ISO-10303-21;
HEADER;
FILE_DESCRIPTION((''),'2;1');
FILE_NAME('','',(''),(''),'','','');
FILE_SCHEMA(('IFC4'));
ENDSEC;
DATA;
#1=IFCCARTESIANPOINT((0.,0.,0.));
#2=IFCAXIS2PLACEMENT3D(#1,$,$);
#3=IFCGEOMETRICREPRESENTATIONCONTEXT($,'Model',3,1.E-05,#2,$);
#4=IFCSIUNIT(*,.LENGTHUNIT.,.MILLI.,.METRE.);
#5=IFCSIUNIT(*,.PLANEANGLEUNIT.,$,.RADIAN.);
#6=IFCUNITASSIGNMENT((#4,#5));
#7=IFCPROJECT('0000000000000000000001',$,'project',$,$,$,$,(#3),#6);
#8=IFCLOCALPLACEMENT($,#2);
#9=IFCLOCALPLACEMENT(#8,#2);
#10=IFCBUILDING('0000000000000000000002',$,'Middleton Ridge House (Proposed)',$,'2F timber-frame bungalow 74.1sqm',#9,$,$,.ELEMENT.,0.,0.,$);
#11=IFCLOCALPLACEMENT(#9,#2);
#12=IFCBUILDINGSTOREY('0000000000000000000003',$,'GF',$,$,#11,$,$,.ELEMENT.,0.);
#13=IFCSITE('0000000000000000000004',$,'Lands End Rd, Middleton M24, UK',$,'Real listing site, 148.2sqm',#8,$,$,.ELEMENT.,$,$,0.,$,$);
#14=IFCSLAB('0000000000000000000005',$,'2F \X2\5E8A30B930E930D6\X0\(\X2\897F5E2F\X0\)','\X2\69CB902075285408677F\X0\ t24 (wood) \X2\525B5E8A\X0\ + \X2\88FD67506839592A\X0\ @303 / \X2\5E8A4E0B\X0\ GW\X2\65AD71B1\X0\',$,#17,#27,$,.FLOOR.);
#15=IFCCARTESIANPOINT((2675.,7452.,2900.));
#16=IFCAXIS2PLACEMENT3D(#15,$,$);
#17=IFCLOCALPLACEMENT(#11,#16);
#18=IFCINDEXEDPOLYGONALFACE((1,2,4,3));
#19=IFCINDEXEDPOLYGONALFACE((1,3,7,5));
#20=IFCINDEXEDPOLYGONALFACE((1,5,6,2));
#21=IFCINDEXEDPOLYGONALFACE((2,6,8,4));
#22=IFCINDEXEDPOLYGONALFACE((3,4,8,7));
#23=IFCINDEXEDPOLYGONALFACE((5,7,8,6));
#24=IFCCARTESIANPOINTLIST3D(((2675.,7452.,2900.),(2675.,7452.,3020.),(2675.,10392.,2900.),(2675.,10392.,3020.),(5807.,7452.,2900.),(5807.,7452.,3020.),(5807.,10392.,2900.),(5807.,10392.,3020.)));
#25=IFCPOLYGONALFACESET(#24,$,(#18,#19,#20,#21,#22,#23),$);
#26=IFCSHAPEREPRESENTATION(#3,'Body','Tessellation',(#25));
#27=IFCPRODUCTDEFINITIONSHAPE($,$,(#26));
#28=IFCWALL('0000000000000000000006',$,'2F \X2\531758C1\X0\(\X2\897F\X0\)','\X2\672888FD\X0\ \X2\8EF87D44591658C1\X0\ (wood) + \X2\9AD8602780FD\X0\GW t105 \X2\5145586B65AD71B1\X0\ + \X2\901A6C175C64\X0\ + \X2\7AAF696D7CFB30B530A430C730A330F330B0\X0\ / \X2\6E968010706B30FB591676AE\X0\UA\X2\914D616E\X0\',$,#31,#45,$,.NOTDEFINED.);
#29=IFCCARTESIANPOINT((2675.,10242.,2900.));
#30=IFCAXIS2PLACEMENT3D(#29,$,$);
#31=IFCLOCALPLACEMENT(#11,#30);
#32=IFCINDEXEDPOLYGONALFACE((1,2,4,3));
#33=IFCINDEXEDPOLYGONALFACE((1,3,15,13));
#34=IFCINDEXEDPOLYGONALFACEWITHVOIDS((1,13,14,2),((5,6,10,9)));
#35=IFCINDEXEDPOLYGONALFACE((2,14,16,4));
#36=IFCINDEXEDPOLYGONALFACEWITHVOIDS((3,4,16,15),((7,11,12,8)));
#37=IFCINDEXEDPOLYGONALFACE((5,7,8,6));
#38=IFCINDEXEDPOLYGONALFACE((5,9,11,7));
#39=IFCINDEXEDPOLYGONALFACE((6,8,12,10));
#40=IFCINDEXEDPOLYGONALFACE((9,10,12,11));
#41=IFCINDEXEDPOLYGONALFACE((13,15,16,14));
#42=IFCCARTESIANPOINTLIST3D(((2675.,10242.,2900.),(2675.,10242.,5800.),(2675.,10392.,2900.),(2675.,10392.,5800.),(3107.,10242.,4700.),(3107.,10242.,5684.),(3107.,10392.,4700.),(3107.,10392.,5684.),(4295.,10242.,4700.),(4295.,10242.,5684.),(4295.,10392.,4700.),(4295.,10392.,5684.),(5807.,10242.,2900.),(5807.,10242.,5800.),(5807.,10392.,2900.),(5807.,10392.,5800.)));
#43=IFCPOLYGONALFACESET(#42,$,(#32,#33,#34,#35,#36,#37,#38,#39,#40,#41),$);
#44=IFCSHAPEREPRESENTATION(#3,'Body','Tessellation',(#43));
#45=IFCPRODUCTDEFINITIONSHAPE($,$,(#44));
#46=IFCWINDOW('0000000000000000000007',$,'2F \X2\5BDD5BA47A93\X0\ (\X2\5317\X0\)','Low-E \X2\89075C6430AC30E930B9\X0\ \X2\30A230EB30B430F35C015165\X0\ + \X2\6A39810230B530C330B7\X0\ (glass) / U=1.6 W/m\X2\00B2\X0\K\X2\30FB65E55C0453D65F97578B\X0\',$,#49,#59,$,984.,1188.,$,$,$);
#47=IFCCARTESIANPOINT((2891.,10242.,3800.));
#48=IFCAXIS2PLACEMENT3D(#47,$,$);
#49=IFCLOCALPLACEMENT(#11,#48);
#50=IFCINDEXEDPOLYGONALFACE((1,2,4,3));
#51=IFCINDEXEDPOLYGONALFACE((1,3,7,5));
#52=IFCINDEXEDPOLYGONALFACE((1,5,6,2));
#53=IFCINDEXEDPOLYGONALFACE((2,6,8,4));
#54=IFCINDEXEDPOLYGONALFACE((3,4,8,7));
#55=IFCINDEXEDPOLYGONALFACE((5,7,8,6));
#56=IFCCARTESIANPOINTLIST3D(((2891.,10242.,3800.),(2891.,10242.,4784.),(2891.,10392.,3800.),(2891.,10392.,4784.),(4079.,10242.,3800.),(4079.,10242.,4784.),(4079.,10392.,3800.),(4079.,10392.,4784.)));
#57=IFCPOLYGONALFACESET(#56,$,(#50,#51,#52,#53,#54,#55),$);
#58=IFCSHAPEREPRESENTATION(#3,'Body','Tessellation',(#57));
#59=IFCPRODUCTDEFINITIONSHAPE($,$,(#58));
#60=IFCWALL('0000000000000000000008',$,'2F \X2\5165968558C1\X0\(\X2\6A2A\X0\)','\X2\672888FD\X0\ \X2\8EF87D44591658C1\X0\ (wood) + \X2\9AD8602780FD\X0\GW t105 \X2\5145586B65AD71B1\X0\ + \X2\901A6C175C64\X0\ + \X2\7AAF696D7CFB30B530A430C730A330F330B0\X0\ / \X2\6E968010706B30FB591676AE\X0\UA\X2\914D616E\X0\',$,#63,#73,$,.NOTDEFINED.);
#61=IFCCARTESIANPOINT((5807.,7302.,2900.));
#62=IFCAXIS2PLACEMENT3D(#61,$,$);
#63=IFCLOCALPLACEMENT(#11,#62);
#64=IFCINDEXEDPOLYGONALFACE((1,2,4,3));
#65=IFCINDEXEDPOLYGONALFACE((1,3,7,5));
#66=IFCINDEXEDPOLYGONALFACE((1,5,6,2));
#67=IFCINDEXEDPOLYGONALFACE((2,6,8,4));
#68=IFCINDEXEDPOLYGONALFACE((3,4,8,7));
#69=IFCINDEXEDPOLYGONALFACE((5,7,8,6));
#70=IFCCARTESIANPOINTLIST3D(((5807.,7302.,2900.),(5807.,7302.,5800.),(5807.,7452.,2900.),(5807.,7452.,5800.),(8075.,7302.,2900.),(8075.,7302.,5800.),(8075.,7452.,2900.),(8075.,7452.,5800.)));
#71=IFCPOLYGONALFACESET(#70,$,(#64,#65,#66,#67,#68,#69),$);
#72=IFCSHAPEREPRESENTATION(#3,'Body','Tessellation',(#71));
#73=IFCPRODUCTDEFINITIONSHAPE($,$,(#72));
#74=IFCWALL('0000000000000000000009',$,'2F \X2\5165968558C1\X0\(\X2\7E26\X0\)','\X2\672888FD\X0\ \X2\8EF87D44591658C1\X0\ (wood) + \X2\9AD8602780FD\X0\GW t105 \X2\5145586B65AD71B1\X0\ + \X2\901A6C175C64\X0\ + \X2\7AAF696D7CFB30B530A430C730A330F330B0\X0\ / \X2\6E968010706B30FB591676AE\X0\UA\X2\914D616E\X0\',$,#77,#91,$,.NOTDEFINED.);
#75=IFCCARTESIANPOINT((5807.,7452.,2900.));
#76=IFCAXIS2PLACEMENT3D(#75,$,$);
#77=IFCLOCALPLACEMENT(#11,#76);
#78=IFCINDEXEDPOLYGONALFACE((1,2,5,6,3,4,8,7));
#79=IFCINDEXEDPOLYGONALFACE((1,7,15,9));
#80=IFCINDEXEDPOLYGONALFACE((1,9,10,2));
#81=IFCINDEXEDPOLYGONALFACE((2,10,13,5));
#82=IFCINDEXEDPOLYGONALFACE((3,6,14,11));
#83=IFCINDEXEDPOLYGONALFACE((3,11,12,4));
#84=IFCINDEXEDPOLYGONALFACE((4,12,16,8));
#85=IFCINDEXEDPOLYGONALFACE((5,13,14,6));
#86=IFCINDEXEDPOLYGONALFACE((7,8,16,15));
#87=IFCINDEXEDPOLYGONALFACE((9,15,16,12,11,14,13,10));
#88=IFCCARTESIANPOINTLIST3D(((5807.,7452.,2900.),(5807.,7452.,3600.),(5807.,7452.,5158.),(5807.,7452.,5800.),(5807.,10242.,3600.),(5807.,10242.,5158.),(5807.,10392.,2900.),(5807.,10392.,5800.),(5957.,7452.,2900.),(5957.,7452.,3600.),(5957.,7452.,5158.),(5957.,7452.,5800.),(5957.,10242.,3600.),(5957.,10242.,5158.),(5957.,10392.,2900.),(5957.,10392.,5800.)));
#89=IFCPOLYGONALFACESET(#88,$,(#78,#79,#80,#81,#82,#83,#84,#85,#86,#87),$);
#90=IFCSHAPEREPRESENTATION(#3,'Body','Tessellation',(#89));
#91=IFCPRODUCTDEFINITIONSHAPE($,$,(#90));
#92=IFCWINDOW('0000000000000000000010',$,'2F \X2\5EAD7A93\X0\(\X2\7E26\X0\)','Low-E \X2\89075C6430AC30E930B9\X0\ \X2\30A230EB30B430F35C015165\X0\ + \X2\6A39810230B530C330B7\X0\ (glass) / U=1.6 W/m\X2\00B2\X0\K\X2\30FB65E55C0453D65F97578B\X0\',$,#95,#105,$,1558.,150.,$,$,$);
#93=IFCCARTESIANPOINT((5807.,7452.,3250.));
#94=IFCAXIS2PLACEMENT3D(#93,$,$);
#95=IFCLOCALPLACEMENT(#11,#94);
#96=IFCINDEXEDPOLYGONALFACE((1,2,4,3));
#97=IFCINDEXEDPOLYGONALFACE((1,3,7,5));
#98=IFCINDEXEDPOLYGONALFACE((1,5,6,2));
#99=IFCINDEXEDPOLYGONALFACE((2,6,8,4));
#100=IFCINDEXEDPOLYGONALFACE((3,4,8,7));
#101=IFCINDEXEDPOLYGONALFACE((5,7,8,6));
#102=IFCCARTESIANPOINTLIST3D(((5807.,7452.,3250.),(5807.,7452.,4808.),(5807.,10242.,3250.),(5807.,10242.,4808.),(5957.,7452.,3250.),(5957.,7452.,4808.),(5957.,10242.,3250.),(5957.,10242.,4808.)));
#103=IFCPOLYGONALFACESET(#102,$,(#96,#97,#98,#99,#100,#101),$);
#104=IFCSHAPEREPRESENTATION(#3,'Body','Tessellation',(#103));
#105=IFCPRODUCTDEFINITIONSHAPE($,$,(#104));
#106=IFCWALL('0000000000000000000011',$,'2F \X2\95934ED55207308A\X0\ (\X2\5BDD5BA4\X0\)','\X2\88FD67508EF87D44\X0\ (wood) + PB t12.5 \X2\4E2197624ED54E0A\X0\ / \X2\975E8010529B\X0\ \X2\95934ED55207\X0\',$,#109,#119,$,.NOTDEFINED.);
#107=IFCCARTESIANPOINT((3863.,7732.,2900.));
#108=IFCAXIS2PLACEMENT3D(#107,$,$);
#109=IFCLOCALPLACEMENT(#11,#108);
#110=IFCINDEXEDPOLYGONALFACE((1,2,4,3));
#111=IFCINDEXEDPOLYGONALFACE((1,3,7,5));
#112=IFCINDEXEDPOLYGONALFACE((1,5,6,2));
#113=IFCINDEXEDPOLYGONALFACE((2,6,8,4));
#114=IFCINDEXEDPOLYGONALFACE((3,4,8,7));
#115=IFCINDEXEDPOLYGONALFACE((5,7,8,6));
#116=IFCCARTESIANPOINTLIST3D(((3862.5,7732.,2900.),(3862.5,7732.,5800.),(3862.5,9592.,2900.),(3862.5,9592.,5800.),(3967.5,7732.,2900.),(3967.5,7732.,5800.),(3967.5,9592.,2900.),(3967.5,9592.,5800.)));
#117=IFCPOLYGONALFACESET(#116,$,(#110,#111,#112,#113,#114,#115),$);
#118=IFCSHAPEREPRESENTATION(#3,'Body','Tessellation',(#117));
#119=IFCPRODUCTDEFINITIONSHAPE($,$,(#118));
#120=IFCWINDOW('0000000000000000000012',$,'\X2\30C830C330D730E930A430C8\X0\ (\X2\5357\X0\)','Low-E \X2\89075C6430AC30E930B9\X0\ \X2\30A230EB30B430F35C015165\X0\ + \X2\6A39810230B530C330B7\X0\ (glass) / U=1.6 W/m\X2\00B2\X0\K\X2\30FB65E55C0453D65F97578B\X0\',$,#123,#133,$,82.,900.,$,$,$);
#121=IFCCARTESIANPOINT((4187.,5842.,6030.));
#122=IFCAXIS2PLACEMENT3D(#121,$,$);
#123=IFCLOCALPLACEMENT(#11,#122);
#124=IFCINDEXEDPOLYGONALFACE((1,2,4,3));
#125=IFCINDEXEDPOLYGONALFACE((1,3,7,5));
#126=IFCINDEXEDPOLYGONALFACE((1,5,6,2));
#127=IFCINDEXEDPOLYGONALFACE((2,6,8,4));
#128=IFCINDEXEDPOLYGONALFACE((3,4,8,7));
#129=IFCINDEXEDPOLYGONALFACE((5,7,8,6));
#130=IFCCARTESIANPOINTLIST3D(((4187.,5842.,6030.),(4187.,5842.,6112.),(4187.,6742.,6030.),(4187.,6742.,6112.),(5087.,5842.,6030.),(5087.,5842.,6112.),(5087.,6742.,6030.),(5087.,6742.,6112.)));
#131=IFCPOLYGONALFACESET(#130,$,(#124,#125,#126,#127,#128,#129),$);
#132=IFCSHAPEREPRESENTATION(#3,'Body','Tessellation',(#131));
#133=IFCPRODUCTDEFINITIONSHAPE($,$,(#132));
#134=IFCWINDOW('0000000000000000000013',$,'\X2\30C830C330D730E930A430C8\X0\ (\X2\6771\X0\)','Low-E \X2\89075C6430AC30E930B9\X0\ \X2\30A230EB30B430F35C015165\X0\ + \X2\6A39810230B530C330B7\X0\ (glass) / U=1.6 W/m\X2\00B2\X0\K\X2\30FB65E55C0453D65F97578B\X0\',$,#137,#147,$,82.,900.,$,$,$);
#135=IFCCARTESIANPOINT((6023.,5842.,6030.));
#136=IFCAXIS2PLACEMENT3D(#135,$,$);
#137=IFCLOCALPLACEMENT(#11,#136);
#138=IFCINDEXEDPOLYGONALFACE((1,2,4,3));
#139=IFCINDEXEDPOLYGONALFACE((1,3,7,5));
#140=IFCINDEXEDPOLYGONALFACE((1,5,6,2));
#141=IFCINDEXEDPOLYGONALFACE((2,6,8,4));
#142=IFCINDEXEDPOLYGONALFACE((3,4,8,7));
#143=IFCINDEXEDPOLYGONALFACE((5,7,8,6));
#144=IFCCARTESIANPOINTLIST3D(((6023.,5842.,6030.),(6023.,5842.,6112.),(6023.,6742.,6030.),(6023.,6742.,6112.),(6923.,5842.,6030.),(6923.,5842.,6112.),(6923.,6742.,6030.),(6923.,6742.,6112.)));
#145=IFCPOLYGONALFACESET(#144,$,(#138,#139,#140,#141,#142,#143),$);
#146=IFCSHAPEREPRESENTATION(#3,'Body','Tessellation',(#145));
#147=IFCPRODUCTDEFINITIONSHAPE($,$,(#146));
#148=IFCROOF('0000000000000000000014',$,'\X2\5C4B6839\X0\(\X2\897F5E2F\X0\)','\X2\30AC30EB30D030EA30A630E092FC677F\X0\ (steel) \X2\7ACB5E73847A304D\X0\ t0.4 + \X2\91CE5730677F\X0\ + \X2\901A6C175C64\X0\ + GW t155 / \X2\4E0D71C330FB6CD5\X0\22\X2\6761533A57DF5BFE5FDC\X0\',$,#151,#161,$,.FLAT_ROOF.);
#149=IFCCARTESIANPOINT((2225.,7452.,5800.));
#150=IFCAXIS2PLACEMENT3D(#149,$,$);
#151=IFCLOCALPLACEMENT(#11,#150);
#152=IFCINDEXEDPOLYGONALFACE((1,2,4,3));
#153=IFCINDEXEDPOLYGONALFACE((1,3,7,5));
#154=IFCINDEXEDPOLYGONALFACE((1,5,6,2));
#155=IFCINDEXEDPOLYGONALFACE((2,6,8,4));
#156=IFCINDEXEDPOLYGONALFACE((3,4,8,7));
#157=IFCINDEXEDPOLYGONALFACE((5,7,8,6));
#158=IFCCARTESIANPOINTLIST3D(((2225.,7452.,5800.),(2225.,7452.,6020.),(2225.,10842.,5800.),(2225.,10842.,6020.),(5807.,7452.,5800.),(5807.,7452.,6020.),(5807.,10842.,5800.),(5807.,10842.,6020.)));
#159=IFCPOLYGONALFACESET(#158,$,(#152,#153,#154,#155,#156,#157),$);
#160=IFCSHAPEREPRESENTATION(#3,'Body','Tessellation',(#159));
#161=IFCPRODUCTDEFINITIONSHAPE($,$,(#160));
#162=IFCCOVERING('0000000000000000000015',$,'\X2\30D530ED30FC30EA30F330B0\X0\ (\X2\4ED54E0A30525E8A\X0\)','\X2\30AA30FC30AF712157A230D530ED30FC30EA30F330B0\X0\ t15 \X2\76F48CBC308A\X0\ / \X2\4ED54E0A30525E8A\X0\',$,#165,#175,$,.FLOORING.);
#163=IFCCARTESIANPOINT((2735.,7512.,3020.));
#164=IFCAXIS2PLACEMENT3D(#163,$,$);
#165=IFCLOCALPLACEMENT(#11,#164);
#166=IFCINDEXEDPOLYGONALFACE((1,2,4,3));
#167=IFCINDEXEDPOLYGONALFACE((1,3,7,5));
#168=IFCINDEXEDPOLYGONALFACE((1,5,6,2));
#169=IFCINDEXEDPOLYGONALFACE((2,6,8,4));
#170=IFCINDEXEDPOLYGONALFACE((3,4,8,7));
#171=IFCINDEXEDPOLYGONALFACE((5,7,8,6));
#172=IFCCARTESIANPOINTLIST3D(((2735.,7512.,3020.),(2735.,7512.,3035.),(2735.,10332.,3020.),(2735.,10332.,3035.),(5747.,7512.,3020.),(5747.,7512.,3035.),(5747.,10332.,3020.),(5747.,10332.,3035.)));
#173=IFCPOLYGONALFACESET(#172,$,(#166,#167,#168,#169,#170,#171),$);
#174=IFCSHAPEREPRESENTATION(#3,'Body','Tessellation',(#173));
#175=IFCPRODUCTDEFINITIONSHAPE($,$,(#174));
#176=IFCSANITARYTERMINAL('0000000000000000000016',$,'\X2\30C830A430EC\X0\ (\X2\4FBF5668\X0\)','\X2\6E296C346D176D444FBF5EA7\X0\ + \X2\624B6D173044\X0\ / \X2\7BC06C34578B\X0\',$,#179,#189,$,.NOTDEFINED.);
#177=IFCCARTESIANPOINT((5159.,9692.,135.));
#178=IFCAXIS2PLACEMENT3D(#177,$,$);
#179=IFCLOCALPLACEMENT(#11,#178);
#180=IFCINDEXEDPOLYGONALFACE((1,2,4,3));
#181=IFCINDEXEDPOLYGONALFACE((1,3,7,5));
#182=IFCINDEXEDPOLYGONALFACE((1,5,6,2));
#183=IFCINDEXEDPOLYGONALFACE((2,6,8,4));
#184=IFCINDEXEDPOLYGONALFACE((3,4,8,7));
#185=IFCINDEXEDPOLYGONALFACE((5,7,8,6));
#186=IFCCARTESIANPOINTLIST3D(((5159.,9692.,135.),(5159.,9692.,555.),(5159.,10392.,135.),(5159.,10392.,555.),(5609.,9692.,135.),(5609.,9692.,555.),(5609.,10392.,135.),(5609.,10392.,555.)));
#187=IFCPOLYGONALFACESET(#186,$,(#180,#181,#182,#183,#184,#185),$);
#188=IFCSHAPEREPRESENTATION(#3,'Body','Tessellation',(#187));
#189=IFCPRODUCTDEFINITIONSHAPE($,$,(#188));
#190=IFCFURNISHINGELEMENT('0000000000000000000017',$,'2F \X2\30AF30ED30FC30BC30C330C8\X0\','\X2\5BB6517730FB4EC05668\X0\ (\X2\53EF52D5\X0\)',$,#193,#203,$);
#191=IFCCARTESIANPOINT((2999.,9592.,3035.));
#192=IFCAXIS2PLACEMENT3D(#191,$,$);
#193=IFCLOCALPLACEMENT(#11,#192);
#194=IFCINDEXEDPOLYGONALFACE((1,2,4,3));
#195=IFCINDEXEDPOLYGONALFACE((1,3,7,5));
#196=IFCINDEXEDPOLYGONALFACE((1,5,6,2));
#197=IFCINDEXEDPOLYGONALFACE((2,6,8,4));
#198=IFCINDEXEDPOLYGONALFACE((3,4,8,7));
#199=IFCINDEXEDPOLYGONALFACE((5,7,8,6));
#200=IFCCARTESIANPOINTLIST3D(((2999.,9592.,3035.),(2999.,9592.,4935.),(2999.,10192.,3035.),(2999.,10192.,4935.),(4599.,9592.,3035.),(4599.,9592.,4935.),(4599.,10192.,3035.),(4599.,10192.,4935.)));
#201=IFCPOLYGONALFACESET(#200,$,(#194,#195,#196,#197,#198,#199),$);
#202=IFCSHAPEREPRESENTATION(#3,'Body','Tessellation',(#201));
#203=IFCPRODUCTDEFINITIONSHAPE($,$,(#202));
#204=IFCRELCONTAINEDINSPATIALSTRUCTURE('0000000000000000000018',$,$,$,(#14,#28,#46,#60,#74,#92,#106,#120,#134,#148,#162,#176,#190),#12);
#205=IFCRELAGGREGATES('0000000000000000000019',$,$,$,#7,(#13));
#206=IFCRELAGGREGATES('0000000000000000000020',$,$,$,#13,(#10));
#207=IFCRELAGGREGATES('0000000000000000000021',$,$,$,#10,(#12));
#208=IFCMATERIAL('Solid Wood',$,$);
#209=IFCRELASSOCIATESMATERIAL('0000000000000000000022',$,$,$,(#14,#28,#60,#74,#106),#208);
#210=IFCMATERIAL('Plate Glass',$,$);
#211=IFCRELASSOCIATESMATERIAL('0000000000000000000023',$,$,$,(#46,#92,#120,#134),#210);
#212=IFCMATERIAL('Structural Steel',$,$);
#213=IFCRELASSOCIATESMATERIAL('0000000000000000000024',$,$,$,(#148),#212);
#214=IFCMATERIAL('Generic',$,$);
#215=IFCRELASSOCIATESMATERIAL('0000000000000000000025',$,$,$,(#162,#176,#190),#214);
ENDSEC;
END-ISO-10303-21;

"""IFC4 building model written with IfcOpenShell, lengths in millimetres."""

from ifc_helpers import new_model, si_unit, frame, frame_2d, origin, place, context, project, spatial, rectangle, extrude, material, element, fill, save


model = new_model("IFC4")

# Units and contexts
model_context = context("Model", 3, precision=1e-05, world=origin())
ifc_project = project(units=[si_unit("LENGTHUNIT", "METRE", prefix="MILLI"), si_unit("PLANEANGLEUNIT", "RADIAN")], contexts=[model_context])

# Site, building, storey
site_placement = place(None, origin())
site = spatial("IfcSite", under=ifc_project, at=site_placement, Name="Lands End Rd, Middleton M24, UK", ObjectType="Real listing site, 148.2sqm", CompositionType="ELEMENT", RefElevation=0.0)
building_placement = place(site_placement, origin())
building = spatial("IfcBuilding", under=site, at=building_placement, Name="Middleton Ridge House (Proposed)", ObjectType="2F timber-frame bungalow 74.1sqm", CompositionType="ELEMENT", ElevationOfRefHeight=0.0, ElevationOfTerrain=0.0)
storey_placement = place(building_placement, origin())
storey = spatial("IfcBuildingStorey", under=building, at=storey_placement, Name="GF", CompositionType="ELEMENT", Elevation=0.0)

# Slab
ifc_material_1 = material(Name="Solid Wood")
slab_placement = place(storey_placement, frame((2675.0, 7452.0, 2900.0)))
element("IfcSlab", 1, at=slab_placement, inside=storey, material=ifc_material_1, Name="2F 床スラブ(西帯)", Description="構造用合板 t24 (wood) 剛床 + 製材根太 @303 / 床下 GW断熱", PredefinedType="FLOOR", context=model_context, shape_type="SweptSolid", body=[
    extrude(rectangle(XDim=3132.0, YDim=2940.0, at=frame_2d((1566.0, 1470.0))), frame((2675.0, 7452.0, 2900.0)), (0.0, 0.0, 1.0), 120.0),
])

# Wall, opening, window
wall_1_placement = place(storey_placement, frame((2675.0, 10242.0, 2900.0)))
wall_1 = element("IfcWall", 2, at=wall_1_placement, inside=storey, material=ifc_material_1, Name="2F 北壁(西)", Description="木製 軸組外壁 (wood) + 高性能GW t105 充填断熱 + 通気層 + 窯業系サイディング / 準耐火・外皮UA配慮", PredefinedType="NOTDEFINED", context=model_context, shape_type="SweptSolid", body=[
    extrude(rectangle(XDim=3132.0, YDim=150.0, at=frame_2d((1566.0, 75.0))), frame((2675.0, 10242.0, 2900.0)), (0.0, 0.0, 1.0), 2900.0),
])
opening_1_placement = place(storey_placement, frame((2891.0, 10242.0, 3800.0)))
opening_1 = element("IfcOpeningElement", 3, at=opening_1_placement, cuts=wall_1, PredefinedType="NOTDEFINED", context=model_context, shape_type="SweptSolid", body=[
    extrude(rectangle(XDim=1188.0, YDim=150.0, at=frame_2d((594.0, 75.0))), frame((2891.0, 10242.0, 3800.0)), (0.0, 0.0, 1.0), 984.0),
])
ifc_material_2 = material(Name="Plate Glass")
window_1_placement = place(storey_placement, frame((2891.0, 10242.0, 3800.0)))
window_1 = element("IfcWindow", 4, at=window_1_placement, inside=storey, material=ifc_material_2, Name="2F 寝室窓 (北)", Description="Low-E 複層ガラス アルゴン封入 + 樹脂サッシ (glass) / U=1.6 W/m²K・日射取得型", OverallHeight=984.0, OverallWidth=1188.0, context=model_context, shape_type="SweptSolid", body=[
    extrude(rectangle(XDim=1188.0, YDim=150.0, at=frame_2d((594.0, 75.0))), frame((2891.0, 10242.0, 3800.0)), (0.0, 0.0, 1.0), 984.0),
])
fill(opening_1, window_1)

# Wall
wall_2_placement = place(storey_placement, frame((5807.0, 7302.0, 2900.0)))
element("IfcWall", 5, at=wall_2_placement, inside=storey, material=ifc_material_1, Name="2F 入隅壁(横)", Description="木製 軸組外壁 (wood) + 高性能GW t105 充填断熱 + 通気層 + 窯業系サイディング / 準耐火・外皮UA配慮", PredefinedType="NOTDEFINED", context=model_context, shape_type="SweptSolid", body=[
    extrude(rectangle(XDim=2268.0, YDim=150.0, at=frame_2d((1134.0, 75.0))), frame((5807.0, 7302.0, 2900.0)), (0.0, 0.0, 1.0), 2900.0),
])

# Wall, opening, window
wall_3_placement = place(storey_placement, frame((5807.0, 7452.0, 2900.0)))
wall_3 = element("IfcWall", 6, at=wall_3_placement, inside=storey, material=ifc_material_1, Name="2F 入隅壁(縦)", Description="木製 軸組外壁 (wood) + 高性能GW t105 充填断熱 + 通気層 + 窯業系サイディング / 準耐火・外皮UA配慮", PredefinedType="NOTDEFINED", context=model_context, shape_type="SweptSolid", body=[
    extrude(rectangle(XDim=150.0, YDim=2940.0, at=frame_2d((75.0, 1470.0))), frame((5807.0, 7452.0, 2900.0)), (0.0, 0.0, 1.0), 2900.0),
])
opening_2_placement = place(storey_placement, frame((5807.0, 7452.0, 3250.0)))
opening_2 = element("IfcOpeningElement", 7, at=opening_2_placement, cuts=wall_3, PredefinedType="NOTDEFINED", context=model_context, shape_type="SweptSolid", body=[
    extrude(rectangle(XDim=150.0, YDim=2790.0, at=frame_2d((75.0, 1395.0))), frame((5807.0, 7452.0, 3250.0)), (0.0, 0.0, 1.0), 1558.0),
])
window_2_placement = place(storey_placement, frame((5807.0, 7452.0, 3250.0)))
window_2 = element("IfcWindow", 8, at=window_2_placement, inside=storey, material=ifc_material_2, Name="2F 庭窓(縦)", Description="Low-E 複層ガラス アルゴン封入 + 樹脂サッシ (glass) / U=1.6 W/m²K・日射取得型", OverallHeight=1558.0, OverallWidth=150.0, context=model_context, shape_type="SweptSolid", body=[
    extrude(rectangle(XDim=150.0, YDim=2790.0, at=frame_2d((75.0, 1395.0))), frame((5807.0, 7452.0, 3250.0)), (0.0, 0.0, 1.0), 1558.0),
])
fill(opening_2, window_2)

# Wall
wall_4_placement = place(storey_placement, frame((3863.0, 7732.0, 2900.0)))
element("IfcWall", 9, at=wall_4_placement, inside=storey, material=ifc_material_1, Name="2F 間仕切り (寝室)", Description="製材軸組 (wood) + PB t12.5 両面仕上 / 非耐力 間仕切", PredefinedType="NOTDEFINED", context=model_context, shape_type="SweptSolid", body=[
    extrude(rectangle(XDim=105.0, YDim=1860.0, at=frame_2d((52.0, 930.0))), frame((3863.0, 7732.0, 2900.0)), (0.0, 0.0, 1.0), 2900.0),
])

# Windows
window_3_placement = place(storey_placement, frame((4187.0, 5842.0, 6030.0)))
element("IfcWindow", 10, at=window_3_placement, inside=storey, material=ifc_material_2, Name="トップライト (南)", Description="Low-E 複層ガラス アルゴン封入 + 樹脂サッシ (glass) / U=1.6 W/m²K・日射取得型", OverallHeight=82.0, OverallWidth=900.0, context=model_context, shape_type="SweptSolid", body=[
    extrude(rectangle(XDim=900.0, YDim=900.0, at=frame_2d((450.0, 450.0))), frame((4187.0, 5842.0, 6030.0)), (0.0, 0.0, 1.0), 82.0),
])
window_4_placement = place(storey_placement, frame((6023.0, 5842.0, 6030.0)))
element("IfcWindow", 11, at=window_4_placement, inside=storey, material=ifc_material_2, Name="トップライト (東)", Description="Low-E 複層ガラス アルゴン封入 + 樹脂サッシ (glass) / U=1.6 W/m²K・日射取得型", OverallHeight=82.0, OverallWidth=900.0, context=model_context, shape_type="SweptSolid", body=[
    extrude(rectangle(XDim=900.0, YDim=900.0, at=frame_2d((450.0, 450.0))), frame((6023.0, 5842.0, 6030.0)), (0.0, 0.0, 1.0), 82.0),
])

# Roof
ifc_material_3 = material(Name="Structural Steel")
for number, where, name in (
    (12, (2225.0, 7452.0, 5800.0), "屋根(西帯)"),
):
    element("IfcRoof", number, at=place(storey_placement, frame(where)), inside=storey, material=ifc_material_3, Name=name, Description="ガルバリウム鋼板 (steel) 立平葺き t0.4 + 野地板 + 通気層 + GW t155 / 不燃・法22条区域対応", PredefinedType="FLAT_ROOF", context=model_context, shape_type="SweptSolid", body=[
        extrude(rectangle(XDim=3582.0, YDim=3390.0, at=frame_2d((1791.0, 1695.0))), frame((2225.0, 7452.0, 5800.0)), (0.0, 0.0, 1.0), 220.0),
    ])

# Covering
ifc_material_4 = material(Name="Generic")
covering_placement = place(storey_placement, frame((2735.0, 7512.0, 3020.0)))
element("IfcCovering", 13, at=covering_placement, inside=storey, material=ifc_material_4, Name="フローリング (仕上げ床)", Description="オーク無垢フローリング t15 直貼り / 仕上げ床", PredefinedType="FLOORING", context=model_context, shape_type="SweptSolid", body=[
    extrude(rectangle(XDim=3012.0, YDim=2820.0, at=frame_2d((1506.0, 1410.0))), frame((2735.0, 7512.0, 3020.0)), (0.0, 0.0, 1.0), 15.0),
])

# Sanitary terminal
sanitary_terminal_placement = place(storey_placement, frame((5159.0, 9692.0, 135.0)))
element("IfcSanitaryTerminal", 14, at=sanitary_terminal_placement, inside=storey, material=ifc_material_4, Name="トイレ (便器)", Description="温水洗浄便座 + 手洗い / 節水型", PredefinedType="NOTDEFINED", context=model_context, shape_type="SweptSolid", body=[
    extrude(rectangle(XDim=450.0, YDim=700.0, at=frame_2d((225.0, 350.0))), frame((5159.0, 9692.0, 135.0)), (0.0, 0.0, 1.0), 420.0),
])

# Furnishing element
furnishing_1_placement = place(storey_placement, frame((2999.0, 9592.0, 3035.0)))
element("IfcFurnishingElement", 15, at=furnishing_1_placement, inside=storey, material=ifc_material_4, Name="2F クローゼット", Description="家具・什器 (可動)", context=model_context, shape_type="SweptSolid", body=[
    extrude(rectangle(XDim=1600.0, YDim=600.0, at=frame_2d((800.0, 300.0))), frame((2999.0, 9592.0, 3035.0)), (0.0, 0.0, 1.0), 1900.0),
])

save(model, "model.ifc")
